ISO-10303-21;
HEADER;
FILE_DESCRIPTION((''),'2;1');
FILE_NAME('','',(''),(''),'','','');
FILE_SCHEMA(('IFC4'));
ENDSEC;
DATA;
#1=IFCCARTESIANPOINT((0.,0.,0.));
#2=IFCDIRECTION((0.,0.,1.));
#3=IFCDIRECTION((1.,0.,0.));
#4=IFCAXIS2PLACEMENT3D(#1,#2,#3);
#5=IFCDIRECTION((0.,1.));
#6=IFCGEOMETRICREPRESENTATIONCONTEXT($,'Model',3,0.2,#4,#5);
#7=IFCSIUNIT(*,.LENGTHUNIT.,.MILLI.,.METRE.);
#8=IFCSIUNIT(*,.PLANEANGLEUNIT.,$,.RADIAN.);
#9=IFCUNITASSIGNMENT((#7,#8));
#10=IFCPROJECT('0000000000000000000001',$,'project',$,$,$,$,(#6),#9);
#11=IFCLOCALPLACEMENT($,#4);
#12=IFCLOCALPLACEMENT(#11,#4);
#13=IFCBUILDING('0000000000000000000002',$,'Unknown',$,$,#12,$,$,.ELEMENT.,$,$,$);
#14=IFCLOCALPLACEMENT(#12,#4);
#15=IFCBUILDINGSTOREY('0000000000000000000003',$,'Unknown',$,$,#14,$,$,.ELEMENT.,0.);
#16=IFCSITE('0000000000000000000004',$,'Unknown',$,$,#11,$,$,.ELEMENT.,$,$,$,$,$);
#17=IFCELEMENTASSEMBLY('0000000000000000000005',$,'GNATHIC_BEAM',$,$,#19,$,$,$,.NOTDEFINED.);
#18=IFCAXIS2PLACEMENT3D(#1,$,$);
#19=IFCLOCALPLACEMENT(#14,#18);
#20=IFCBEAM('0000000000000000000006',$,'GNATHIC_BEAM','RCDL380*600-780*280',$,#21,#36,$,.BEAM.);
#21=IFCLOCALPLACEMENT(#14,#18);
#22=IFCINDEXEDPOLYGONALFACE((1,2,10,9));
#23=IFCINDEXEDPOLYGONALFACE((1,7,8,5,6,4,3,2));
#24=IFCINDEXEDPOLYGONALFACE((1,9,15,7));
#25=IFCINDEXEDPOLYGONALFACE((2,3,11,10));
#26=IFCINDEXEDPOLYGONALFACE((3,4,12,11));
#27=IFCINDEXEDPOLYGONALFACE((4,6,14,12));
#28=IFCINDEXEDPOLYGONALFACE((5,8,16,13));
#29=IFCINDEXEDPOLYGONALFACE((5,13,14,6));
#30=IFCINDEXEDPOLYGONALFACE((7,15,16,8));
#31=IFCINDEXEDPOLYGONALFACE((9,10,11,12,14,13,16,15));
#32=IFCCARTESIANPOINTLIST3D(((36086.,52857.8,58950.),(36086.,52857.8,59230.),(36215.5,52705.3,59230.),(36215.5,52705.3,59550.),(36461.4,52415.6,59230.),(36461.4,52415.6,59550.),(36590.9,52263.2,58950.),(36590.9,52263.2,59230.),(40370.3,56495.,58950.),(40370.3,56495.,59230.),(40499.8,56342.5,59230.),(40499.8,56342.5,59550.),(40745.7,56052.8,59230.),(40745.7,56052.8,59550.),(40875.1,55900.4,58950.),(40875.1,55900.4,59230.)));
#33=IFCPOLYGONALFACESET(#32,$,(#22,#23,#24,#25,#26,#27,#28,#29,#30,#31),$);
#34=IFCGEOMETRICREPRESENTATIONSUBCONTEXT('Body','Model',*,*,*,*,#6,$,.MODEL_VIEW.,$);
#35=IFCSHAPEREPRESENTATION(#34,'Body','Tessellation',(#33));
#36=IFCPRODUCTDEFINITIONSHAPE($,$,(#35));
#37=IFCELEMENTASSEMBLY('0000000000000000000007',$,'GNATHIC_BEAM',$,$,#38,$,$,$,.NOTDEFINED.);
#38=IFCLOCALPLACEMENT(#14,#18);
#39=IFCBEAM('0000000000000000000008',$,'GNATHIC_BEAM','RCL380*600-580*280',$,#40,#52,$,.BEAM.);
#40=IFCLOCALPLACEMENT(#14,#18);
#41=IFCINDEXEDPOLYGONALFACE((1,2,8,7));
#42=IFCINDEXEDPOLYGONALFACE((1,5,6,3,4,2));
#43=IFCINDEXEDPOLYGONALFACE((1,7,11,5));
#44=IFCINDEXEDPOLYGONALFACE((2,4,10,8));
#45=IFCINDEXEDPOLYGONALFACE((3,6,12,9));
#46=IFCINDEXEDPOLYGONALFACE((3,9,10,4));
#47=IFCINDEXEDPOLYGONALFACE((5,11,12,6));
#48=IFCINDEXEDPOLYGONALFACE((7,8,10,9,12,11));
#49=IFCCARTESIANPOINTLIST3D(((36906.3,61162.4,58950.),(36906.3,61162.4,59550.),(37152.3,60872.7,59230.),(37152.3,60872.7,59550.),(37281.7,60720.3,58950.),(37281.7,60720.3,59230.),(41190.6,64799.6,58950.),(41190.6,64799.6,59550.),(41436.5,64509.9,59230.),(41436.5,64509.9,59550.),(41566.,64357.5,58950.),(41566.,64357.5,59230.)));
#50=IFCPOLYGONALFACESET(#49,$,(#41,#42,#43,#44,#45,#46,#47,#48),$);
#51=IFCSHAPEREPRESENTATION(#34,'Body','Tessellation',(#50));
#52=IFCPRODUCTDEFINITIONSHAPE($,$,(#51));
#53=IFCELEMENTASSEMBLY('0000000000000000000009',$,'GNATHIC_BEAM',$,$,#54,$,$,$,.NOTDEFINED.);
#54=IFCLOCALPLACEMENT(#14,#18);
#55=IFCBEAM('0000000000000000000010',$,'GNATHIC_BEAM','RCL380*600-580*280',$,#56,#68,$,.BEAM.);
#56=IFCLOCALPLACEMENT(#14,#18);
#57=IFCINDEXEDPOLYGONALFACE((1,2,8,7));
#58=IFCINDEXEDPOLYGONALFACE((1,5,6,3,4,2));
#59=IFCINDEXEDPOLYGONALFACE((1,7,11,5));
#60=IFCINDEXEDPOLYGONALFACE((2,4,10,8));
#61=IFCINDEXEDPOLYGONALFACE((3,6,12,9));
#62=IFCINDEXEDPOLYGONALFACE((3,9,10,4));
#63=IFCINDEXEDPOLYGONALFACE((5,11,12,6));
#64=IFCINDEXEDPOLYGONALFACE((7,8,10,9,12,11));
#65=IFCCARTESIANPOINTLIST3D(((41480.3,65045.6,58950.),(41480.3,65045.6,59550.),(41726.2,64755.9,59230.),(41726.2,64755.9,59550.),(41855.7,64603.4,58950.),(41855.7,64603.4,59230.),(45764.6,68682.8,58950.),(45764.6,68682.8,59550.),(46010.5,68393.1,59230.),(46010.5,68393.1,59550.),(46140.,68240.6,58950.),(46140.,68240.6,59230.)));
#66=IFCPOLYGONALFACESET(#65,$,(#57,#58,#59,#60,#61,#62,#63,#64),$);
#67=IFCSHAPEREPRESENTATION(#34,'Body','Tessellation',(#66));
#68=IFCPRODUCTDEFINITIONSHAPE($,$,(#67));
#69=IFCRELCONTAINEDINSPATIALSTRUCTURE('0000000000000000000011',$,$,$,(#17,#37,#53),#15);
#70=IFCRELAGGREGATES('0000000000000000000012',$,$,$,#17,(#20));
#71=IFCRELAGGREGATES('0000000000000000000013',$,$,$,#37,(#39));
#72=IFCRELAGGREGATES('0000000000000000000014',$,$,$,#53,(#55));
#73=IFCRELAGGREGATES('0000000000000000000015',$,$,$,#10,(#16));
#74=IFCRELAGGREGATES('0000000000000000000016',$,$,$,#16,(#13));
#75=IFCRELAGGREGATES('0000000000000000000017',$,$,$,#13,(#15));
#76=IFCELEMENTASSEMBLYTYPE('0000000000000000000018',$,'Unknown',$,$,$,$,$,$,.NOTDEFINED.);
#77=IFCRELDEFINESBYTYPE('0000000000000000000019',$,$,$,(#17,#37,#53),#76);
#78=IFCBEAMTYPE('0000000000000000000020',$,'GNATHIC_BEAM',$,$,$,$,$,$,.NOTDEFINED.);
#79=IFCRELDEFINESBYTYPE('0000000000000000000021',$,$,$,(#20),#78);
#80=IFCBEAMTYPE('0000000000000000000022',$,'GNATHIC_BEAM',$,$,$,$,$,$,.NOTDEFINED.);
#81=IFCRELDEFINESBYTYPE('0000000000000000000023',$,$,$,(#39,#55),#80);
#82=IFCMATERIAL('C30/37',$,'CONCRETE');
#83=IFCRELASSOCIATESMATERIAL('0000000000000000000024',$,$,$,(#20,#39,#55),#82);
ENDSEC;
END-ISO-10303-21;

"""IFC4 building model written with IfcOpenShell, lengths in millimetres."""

from ifc_helpers import new_model, si_unit, direction, frame, origin_with_axes, place, context, subcontext, project, spatial, polyline, outline, extrude, material, material_profile, profile_set, profile_usage, type_object, element, aggregate, save


model = new_model("IFC4")

# Units and contexts
model_context = context("Model", 3, precision=0.2, world=origin_with_axes(), true_north=direction((0.0, 1.0)))
body_context = subcontext(model_context, "Body", "Model", "MODEL_VIEW")
ifc_project = project(units=[si_unit("LENGTHUNIT", "METRE", prefix="MILLI"), si_unit("PLANEANGLEUNIT", "RADIAN")], contexts=[model_context])

# Site, building, storey
site_placement = place(None, origin_with_axes())
site = spatial("IfcSite", under=ifc_project, at=site_placement, Name="Unknown", CompositionType="ELEMENT")
building_placement = place(site_placement, origin_with_axes())
building = spatial("IfcBuilding", under=site, at=building_placement, Name="Unknown", CompositionType="ELEMENT")
storey_placement = place(building_placement, origin_with_axes())
storey = spatial("IfcBuildingStorey", under=building, at=storey_placement, Name="Unknown", CompositionType="ELEMENT", Elevation=0.0)

# Shared definitions
element_assembly_type = type_object("IfcElementAssemblyType", Name="Unknown", PredefinedType="NOTDEFINED")

# Element assemblies, beams
ifc_material_1 = material(Name="C30/37", Category="CONCRETE")
ifc_material_profile_1 = material_profile(ifc_material_1, outline(polyline([(-390.0, -300.0), (390.0, -300.0), (390.0, -20.0), (190.0, -20.0), (190.0, 300.0), (-190.0, 300.0), (-190.0, -20.0), (-390.0, -20.0), (-390.0, -300.0)])), Name="RCDL380*600-780*280")
ifc_profile_set_1 = profile_set([ifc_material_profile_1])
ifc_profile_usage_1 = profile_usage(ifc_profile_set_1, cardinal=2)
beam_type_1 = type_object("IfcBeamType", Name="GNATHIC_BEAM")
assembly_1_placement = place(storey_placement, frame((36338.5, 52560.5, 59250.0), z_axis=(0.64719, -0.762329, 0.0), x_axis=(0.762329, 0.64719, 0.0)))
assembly_1 = element("IfcElementAssembly", 1, at=assembly_1_placement, inside=storey, type_object=element_assembly_type, Name="GNATHIC_BEAM", PredefinedType="NOTDEFINED")
beam_1_placement = place(assembly_1_placement, origin_with_axes())
beam_1 = element("IfcBeam", 2, at=beam_1_placement, type_object=beam_type_1, material=ifc_profile_usage_1, Name="GNATHIC_BEAM", Description="RCDL380*600-780*280", PredefinedType="BEAM", context=body_context, shape_type="SolidModel", body=[
    extrude(outline(polyline([(-390.0, -300.0), (390.0, -300.0), (390.0, -20.0), (190.0, -20.0), (190.0, 300.0), (-190.0, 300.0), (-190.0, -20.0), (-390.0, -20.0), (-390.0, -300.0)])), frame((0.0, 0.0, 0.0), z_axis=(-1.0, 0.0, 0.0), x_axis=(0.0, 0.0, 1.0)), (0.0, 0.0, -1.0), 5620.0),
])
aggregate(assembly_1, [beam_1])
assembly_2_placement = place(storey_placement, frame((37029.3, 61017.6, 59250.0), z_axis=(0.64719, -0.762329, 0.0), x_axis=(0.762329, 0.64719, 0.0)))
assembly_2 = element("IfcElementAssembly", 3, at=assembly_2_placement, inside=storey, type_object=element_assembly_type, Name="GNATHIC_BEAM", PredefinedType="NOTDEFINED")
ifc_material_profile_2 = material_profile(ifc_material_1, outline(polyline([(-190.0, -300.0), (390.0, -300.0), (390.0, -20.0), (190.0, -20.0), (190.0, 300.0), (-190.0, 300.0), (-190.0, -300.0)])), Name="RCL380*600-580*280")
ifc_profile_set_2 = profile_set([ifc_material_profile_2])
ifc_profile_usage_2 = profile_usage(ifc_profile_set_2, cardinal=2)
beam_type_2 = type_object("IfcBeamType", Name="GNATHIC_BEAM")
beam_2_placement = place(assembly_2_placement, origin_with_axes())
beam_2 = element("IfcBeam", 4, at=beam_2_placement, type_object=beam_type_2, material=ifc_profile_usage_2, Name="GNATHIC_BEAM", Description="RCL380*600-580*280", PredefinedType="BEAM", context=body_context, shape_type="SolidModel", body=[
    extrude(outline(polyline([(-190.0, -300.0), (390.0, -300.0), (390.0, -20.0), (190.0, -20.0), (190.0, 300.0), (-190.0, 300.0), (-190.0, -300.0)])), frame((0.0, 0.0, 0.0), z_axis=(-1.0, 0.0, 0.0), x_axis=(0.0, 0.0, 1.0)), (0.0, 0.0, -1.0), 5620.0),
])
aggregate(assembly_2, [beam_2])
assembly_3_placement = place(storey_placement, frame((41603.3, 64900.7, 59250.0), z_axis=(0.64719, -0.762329, 0.0), x_axis=(0.762329, 0.64719, 0.0)))
assembly_3 = element("IfcElementAssembly", 5, at=assembly_3_placement, inside=storey, type_object=element_assembly_type, Name="GNATHIC_BEAM", PredefinedType="NOTDEFINED")
beam_3_placement = place(assembly_3_placement, origin_with_axes())
beam_3 = element("IfcBeam", 6, at=beam_3_placement, type_object=beam_type_2, material=ifc_profile_usage_2, Name="GNATHIC_BEAM", Description="RCL380*600-580*280", PredefinedType="BEAM", context=body_context, shape_type="SolidModel", body=[
    extrude(outline(polyline([(-190.0, -300.0), (390.0, -300.0), (390.0, -20.0), (190.0, -20.0), (190.0, 300.0), (-190.0, 300.0), (-190.0, -300.0)])), frame((0.0, 0.0, 0.0), z_axis=(-1.0, 0.0, 0.0), x_axis=(0.0, 0.0, 1.0)), (0.0, 0.0, -1.0), 5620.0),
])
aggregate(assembly_3, [beam_3])

save(model, "model.ifc")
